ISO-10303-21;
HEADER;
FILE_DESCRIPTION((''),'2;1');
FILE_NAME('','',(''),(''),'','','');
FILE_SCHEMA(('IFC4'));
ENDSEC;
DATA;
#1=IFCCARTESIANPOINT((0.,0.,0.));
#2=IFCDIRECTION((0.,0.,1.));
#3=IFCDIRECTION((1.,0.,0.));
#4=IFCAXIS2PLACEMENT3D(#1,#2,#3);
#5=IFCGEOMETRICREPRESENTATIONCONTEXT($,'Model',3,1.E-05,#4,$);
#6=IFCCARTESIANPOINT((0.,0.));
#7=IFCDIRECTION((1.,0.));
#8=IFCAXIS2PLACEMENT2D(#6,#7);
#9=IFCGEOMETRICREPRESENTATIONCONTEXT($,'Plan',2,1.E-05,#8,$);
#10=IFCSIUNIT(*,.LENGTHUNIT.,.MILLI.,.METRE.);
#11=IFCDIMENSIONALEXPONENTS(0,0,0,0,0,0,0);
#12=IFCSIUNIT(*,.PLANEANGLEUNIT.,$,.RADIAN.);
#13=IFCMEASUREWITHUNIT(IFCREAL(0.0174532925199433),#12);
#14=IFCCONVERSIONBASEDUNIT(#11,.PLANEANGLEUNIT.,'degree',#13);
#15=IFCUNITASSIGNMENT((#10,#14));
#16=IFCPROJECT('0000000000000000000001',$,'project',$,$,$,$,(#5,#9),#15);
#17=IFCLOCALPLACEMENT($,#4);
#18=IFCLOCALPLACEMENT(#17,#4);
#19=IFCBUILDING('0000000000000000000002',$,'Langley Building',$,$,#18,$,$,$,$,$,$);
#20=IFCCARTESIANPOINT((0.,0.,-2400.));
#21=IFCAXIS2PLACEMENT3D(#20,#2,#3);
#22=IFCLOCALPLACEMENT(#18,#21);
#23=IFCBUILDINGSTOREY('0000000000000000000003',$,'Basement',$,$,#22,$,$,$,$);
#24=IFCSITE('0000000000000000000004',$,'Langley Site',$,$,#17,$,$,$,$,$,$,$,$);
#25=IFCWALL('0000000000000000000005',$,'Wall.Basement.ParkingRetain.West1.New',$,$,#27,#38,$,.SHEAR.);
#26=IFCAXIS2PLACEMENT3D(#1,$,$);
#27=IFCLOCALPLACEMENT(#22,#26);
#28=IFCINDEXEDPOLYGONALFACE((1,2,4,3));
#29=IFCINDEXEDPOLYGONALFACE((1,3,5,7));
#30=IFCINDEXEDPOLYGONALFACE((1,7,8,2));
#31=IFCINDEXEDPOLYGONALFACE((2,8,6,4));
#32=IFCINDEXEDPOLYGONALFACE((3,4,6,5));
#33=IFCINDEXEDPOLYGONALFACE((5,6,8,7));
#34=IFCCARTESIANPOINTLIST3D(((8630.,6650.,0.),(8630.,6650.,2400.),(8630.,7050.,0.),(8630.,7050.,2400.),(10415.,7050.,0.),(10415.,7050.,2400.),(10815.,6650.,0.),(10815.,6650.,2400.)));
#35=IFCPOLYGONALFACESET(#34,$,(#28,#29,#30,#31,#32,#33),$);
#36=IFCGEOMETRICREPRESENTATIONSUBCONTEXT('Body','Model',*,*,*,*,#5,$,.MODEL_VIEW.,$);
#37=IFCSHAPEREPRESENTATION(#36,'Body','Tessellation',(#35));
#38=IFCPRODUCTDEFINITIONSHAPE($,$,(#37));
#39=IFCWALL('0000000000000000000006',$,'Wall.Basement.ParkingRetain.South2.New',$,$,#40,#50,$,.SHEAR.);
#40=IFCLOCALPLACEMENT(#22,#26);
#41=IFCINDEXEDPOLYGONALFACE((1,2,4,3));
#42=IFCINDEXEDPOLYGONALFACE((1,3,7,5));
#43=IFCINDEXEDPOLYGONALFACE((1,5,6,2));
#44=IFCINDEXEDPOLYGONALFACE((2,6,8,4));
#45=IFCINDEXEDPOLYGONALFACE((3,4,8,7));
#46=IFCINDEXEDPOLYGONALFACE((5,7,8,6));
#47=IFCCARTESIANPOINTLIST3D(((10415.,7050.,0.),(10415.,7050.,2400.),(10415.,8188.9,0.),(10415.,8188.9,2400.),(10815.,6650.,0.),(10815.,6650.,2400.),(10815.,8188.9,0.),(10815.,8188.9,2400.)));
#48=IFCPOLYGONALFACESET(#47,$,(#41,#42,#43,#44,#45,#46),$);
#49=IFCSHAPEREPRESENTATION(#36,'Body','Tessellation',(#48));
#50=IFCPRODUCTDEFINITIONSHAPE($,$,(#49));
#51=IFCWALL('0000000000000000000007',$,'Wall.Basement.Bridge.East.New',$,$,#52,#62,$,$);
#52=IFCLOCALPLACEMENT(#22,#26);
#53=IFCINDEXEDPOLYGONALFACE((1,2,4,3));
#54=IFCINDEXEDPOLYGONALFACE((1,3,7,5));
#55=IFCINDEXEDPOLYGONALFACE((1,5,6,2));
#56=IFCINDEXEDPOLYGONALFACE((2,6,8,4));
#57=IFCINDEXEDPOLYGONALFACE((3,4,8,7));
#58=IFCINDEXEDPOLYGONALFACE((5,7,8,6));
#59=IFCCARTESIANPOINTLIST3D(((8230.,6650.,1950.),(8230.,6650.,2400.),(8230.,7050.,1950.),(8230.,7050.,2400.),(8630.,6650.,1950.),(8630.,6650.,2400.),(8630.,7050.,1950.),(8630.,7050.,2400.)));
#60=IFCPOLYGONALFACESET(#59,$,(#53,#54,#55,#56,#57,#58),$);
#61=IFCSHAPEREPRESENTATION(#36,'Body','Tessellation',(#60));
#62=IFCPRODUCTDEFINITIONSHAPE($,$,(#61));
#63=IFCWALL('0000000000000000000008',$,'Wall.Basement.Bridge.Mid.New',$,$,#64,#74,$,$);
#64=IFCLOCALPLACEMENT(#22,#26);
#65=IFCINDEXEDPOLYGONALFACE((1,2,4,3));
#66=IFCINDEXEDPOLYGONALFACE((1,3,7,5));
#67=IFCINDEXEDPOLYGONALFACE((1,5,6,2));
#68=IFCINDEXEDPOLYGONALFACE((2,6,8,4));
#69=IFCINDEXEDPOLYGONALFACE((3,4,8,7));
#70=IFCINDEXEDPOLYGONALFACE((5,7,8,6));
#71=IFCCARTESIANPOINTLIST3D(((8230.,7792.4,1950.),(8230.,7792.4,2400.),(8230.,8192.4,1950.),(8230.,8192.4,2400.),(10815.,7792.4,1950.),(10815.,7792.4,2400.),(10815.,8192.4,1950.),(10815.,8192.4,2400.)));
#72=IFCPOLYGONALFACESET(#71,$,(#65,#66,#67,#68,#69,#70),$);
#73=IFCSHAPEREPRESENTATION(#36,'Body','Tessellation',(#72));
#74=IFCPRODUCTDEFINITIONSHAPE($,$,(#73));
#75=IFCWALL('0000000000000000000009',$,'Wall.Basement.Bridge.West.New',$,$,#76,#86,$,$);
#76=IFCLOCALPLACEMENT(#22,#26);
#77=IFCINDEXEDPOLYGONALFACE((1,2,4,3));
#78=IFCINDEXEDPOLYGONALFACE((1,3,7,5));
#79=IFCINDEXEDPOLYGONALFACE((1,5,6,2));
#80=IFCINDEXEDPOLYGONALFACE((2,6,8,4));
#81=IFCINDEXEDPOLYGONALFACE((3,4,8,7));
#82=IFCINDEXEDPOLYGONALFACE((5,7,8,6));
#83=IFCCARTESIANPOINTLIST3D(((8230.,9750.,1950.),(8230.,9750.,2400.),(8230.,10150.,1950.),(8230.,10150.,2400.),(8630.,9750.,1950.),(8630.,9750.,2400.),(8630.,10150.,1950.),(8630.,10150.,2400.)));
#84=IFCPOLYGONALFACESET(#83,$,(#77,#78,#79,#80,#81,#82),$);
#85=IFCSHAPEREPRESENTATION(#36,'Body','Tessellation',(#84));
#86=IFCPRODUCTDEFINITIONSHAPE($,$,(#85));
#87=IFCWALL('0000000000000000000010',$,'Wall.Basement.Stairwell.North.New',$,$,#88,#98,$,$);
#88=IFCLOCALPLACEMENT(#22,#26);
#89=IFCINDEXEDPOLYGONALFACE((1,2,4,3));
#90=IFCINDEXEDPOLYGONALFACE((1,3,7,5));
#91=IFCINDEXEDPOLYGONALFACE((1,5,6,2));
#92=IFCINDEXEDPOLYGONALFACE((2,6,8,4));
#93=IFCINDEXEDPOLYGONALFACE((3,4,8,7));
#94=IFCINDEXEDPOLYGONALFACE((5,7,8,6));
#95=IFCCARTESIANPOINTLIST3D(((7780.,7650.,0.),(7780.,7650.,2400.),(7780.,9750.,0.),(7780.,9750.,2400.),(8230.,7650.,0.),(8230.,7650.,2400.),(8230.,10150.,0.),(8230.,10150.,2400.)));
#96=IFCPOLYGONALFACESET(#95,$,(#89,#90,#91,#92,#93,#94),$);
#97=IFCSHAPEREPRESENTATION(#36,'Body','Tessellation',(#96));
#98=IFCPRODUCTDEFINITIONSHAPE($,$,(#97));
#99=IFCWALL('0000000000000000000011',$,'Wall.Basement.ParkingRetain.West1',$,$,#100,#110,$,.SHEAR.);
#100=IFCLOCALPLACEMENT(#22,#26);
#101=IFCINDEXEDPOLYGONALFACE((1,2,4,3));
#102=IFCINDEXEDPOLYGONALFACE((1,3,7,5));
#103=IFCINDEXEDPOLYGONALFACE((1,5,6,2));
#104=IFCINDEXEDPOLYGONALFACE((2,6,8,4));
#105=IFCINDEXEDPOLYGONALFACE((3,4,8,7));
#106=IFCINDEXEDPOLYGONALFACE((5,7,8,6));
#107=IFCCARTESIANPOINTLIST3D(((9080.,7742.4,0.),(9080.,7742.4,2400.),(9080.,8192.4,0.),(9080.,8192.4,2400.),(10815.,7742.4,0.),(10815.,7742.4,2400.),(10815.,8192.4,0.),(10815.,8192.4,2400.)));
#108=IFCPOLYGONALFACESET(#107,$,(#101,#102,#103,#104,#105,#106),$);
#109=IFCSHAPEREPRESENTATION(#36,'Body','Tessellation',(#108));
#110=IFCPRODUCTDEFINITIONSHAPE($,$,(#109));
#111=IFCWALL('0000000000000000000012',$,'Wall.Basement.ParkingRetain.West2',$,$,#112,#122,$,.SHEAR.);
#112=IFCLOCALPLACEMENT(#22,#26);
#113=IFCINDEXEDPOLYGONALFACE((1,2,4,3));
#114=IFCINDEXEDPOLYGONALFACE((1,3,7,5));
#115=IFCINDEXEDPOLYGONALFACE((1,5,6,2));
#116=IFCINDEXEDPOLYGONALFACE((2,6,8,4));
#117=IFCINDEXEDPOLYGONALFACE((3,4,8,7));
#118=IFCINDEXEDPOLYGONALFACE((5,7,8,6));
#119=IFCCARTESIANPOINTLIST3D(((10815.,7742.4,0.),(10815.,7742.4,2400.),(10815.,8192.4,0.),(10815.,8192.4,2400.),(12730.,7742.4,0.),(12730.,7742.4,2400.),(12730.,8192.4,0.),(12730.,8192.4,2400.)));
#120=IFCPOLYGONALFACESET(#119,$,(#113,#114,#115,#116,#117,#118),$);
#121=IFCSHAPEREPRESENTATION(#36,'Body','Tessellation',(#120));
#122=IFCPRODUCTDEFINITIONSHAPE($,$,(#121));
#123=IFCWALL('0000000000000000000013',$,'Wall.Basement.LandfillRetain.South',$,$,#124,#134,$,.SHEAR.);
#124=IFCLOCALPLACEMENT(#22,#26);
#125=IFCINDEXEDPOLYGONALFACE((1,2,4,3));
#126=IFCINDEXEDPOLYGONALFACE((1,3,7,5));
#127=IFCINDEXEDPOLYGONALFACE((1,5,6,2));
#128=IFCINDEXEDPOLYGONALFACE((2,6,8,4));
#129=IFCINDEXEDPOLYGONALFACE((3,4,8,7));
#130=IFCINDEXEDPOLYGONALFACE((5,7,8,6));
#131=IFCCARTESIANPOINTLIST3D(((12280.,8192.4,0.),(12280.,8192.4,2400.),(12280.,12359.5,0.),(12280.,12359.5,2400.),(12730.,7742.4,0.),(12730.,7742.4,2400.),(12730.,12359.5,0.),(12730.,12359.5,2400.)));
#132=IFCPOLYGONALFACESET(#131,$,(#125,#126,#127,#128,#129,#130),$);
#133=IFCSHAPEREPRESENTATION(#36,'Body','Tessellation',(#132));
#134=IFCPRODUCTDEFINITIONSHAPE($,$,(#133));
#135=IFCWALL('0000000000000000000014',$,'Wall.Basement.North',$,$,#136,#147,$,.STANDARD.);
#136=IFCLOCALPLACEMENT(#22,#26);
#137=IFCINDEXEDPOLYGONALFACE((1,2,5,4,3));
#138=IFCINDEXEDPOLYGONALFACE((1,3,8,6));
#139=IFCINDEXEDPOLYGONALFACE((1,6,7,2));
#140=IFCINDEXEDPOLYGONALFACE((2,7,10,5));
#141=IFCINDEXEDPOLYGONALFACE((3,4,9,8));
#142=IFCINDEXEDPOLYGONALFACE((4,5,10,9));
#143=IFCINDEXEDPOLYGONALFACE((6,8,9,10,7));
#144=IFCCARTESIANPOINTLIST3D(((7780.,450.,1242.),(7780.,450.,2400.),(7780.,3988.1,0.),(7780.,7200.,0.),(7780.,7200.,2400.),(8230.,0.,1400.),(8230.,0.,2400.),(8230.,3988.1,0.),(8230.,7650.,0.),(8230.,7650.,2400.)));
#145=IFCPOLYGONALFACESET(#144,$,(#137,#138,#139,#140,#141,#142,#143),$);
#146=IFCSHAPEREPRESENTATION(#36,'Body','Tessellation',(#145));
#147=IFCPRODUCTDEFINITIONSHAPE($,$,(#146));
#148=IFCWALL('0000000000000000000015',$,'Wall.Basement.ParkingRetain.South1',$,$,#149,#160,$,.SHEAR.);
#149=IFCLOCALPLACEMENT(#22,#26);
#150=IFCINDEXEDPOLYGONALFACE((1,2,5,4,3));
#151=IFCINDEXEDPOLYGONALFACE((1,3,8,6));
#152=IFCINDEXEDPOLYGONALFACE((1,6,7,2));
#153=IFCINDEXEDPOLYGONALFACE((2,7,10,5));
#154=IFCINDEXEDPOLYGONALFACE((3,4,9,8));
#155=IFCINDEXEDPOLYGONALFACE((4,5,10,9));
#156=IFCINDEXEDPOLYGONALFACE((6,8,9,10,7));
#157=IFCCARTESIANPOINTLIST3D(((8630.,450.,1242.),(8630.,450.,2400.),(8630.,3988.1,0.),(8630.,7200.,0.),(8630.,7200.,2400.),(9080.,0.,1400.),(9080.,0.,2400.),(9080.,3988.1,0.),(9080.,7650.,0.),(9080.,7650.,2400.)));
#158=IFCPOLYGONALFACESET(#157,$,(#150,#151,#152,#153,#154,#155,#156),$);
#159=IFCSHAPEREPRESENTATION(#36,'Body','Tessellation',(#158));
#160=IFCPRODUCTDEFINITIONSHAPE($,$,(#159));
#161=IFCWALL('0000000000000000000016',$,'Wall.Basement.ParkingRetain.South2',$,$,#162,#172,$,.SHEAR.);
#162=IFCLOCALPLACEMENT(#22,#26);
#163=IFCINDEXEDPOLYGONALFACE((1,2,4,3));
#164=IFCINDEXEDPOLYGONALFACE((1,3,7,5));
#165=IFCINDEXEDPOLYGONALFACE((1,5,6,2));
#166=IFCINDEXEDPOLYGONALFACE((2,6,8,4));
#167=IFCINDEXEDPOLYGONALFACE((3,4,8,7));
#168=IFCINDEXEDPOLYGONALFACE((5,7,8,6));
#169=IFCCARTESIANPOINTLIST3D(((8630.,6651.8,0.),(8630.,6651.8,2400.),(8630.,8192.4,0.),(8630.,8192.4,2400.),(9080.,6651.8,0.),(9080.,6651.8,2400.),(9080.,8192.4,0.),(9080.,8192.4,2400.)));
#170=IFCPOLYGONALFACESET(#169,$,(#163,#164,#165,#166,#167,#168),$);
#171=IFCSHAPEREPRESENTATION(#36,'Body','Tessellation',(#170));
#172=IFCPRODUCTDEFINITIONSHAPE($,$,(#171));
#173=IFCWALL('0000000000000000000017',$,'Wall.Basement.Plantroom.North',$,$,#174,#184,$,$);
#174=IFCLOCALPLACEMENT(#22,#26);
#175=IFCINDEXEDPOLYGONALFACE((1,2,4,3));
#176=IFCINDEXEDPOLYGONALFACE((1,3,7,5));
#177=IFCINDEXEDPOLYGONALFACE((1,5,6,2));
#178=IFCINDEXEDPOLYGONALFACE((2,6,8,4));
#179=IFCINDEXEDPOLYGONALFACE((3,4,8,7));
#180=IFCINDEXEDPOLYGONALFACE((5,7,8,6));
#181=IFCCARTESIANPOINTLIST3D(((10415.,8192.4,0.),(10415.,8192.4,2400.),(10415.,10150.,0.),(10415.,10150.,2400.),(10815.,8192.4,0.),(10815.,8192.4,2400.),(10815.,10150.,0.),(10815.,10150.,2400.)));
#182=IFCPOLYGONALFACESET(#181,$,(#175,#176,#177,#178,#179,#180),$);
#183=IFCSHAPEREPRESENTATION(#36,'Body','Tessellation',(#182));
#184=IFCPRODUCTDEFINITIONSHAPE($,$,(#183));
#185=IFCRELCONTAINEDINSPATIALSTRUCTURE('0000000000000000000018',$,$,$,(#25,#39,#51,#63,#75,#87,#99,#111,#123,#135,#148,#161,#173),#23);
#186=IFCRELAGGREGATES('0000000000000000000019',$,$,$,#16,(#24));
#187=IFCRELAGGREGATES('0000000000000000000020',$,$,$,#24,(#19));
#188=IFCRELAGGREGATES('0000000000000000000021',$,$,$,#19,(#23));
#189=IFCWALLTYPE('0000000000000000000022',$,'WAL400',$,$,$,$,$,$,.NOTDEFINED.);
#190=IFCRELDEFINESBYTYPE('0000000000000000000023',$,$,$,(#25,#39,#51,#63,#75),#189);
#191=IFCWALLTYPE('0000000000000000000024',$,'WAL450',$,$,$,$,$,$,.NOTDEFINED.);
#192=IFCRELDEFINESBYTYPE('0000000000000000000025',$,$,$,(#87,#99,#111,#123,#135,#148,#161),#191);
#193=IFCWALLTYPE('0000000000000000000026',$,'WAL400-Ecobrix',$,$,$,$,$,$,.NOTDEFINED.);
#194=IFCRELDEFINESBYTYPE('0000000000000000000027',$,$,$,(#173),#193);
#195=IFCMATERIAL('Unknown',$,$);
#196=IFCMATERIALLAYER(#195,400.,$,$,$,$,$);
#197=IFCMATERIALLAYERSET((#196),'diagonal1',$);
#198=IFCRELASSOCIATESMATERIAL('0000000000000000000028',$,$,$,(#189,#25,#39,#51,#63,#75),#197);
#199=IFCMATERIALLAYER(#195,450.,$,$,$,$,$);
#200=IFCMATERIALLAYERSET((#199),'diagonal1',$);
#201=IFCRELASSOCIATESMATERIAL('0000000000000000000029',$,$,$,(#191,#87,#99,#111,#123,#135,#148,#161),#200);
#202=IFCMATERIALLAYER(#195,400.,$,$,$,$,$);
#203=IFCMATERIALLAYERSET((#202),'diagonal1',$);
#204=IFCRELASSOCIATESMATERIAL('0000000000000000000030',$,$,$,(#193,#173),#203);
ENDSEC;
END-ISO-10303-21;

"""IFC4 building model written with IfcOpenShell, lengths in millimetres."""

from ifc_helpers import new_model, entity, si_unit, converted_unit, frame, origin_with_axes, origin_2d_with_axis, place, context, subcontext, project, spatial, line, indexed_curve, outline, extrude, clip, halfspace, material, layer, layer_set, layer_usage, type_object, element, save


model = new_model("IFC4")

# Units and contexts
model_context = context("Model", 3, precision=1e-05, world=origin_with_axes())
plan_context = context("Plan", 2, precision=1e-05, world=origin_2d_with_axis())
body_context_1 = subcontext(model_context, "Body", "Model", "MODEL_VIEW")
ifc_project = project(units=[si_unit("LENGTHUNIT", "METRE", prefix="MILLI"), converted_unit("PLANEANGLEUNIT", "degree", entity("IfcReal", 0.0174532925199433), si_unit("PLANEANGLEUNIT", "RADIAN"), dimensions=[0, 0, 0, 0, 0, 0, 0])], contexts=[model_context, plan_context])

# Site, building, storey
site_placement = place(None, origin_with_axes())
site = spatial("IfcSite", under=ifc_project, at=site_placement, Name="Langley Site")
building_placement = place(site_placement, origin_with_axes())
building = spatial("IfcBuilding", under=site, at=building_placement, Name="Langley Building")
storey_placement = place(building_placement, frame((0.0, 0.0, -2400.0), z_axis=(0.0, 0.0, 1.0), x_axis=(1.0, 0.0, 0.0)))
storey = spatial("IfcBuildingStorey", under=building, at=storey_placement, Name="Basement")

# Walls
ifc_material = material(Name="Unknown")
ifc_layer_1 = layer(ifc_material, 400.0)
ifc_layer_set_1 = layer_set([ifc_layer_1], Name="diagonal1")
ifc_layer_usage_1 = layer_usage(ifc_layer_set_1, "AXIS2", "POSITIVE", 0.0)
wall_type_1 = type_object("IfcWallType", Name="WAL400", PredefinedType="NOTDEFINED", material=ifc_layer_set_1)
wall_1_placement = place(storey_placement, frame((8630.0, 6650.0, 0.0), z_axis=(0.0, 0.0, 1.0), x_axis=(1.0, 0.0, 0.0)))
element("IfcWall", 1, at=wall_1_placement, inside=storey, type_object=wall_type_1, material=ifc_layer_usage_1, Name="Wall.Basement.ParkingRetain.West1.New", PredefinedType="SHEAR", context=body_context_1, shape_type="SweptSolid", body=[
    extrude(outline(indexed_curve([(0.0, 0.0), (0.0, 400.0), (1785.0, 400.0), (2185.0, 0.0)], segments=[line(1, 2, 3, 4, 1)])), origin_with_axes(), (0.0, 0.0, 1.0), 2400.0),
])
ifc_layer_usage_2 = layer_usage(ifc_layer_set_1, "AXIS2", "POSITIVE", 0.0)
wall_2_placement = place(storey_placement, frame((10815.0, 6650.0, 0.0), z_axis=(0.0, 0.0, 1.0), x_axis=(0.0, 1.0, 0.0)))
element("IfcWall", 2, at=wall_2_placement, inside=storey, type_object=wall_type_1, material=ifc_layer_usage_2, Name="Wall.Basement.ParkingRetain.South2.New", PredefinedType="SHEAR", context=body_context_1, shape_type="SweptSolid", body=[
    extrude(outline(indexed_curve([(0.0, 0.0), (400.0, 400.0), (1538.9, 400.0), (1538.9, 0.0)], segments=[line(1, 2, 3, 4, 1)])), origin_with_axes(), (0.0, 0.0, 1.0), 2400.0),
])
ifc_layer_usage_3 = layer_usage(ifc_layer_set_1, "AXIS2", "POSITIVE", 0.0)
wall_3_placement = place(storey_placement, frame((8630.0, 7050.0, 1950.0), z_axis=(0.0, 0.0, 1.0), x_axis=(-1.0, 0.0, 0.0)))
element("IfcWall", 3, at=wall_3_placement, inside=storey, type_object=wall_type_1, material=ifc_layer_usage_3, Name="Wall.Basement.Bridge.East.New", context=body_context_1, shape_type="SweptSolid", body=[
    extrude(outline(indexed_curve([(0.0, 0.0), (0.0, 400.0), (400.0, 400.0), (400.0, 0.0)], segments=[line(1, 2, 3, 4, 1)])), origin_with_axes(), (0.0, 0.0, 1.0), 450.0),
])
ifc_layer_usage_4 = layer_usage(ifc_layer_set_1, "AXIS2", "POSITIVE", 0.0)
wall_4_placement = place(storey_placement, frame((10815.0, 8192.4, 1950.0), z_axis=(0.0, 0.0, 1.0), x_axis=(-1.0, 0.0, 0.0)))
element("IfcWall", 4, at=wall_4_placement, inside=storey, type_object=wall_type_1, material=ifc_layer_usage_4, Name="Wall.Basement.Bridge.Mid.New", context=body_context_1, shape_type="SweptSolid", body=[
    extrude(outline(indexed_curve([(0.0, 0.0), (0.0, 400.0), (2585.0, 400.0), (2585.0, 0.0)], segments=[line(1, 2, 3, 4, 1)])), origin_with_axes(), (0.0, 0.0, 1.0), 450.0),
])
ifc_layer_usage_5 = layer_usage(ifc_layer_set_1, "AXIS2", "POSITIVE", 0.0)
wall_5_placement = place(storey_placement, frame((8630.0, 10150.0, 1950.0), z_axis=(0.0, 0.0, 1.0), x_axis=(-1.0, 0.0, 0.0)))
element("IfcWall", 5, at=wall_5_placement, inside=storey, type_object=wall_type_1, material=ifc_layer_usage_5, Name="Wall.Basement.Bridge.West.New", context=body_context_1, shape_type="SweptSolid", body=[
    extrude(outline(indexed_curve([(0.0, 0.0), (0.0, 400.0), (400.0, 400.0), (400.0, 0.0)], segments=[line(1, 2, 3, 4, 1)])), origin_with_axes(), (0.0, 0.0, 1.0), 450.0),
])
ifc_layer_2 = layer(ifc_material, 450.0)
ifc_layer_set_2 = layer_set([ifc_layer_2], Name="diagonal1")
ifc_layer_usage_6 = layer_usage(ifc_layer_set_2, "AXIS2", "POSITIVE", 0.0)
wall_type_2 = type_object("IfcWallType", Name="WAL450", PredefinedType="NOTDEFINED", material=ifc_layer_set_2)
wall_6_placement = place(storey_placement, frame((8230.0, 7650.0, 0.0), z_axis=(0.0, 0.0, 1.0), x_axis=(-0.000001, 1.0, 0.0)))
element("IfcWall", 6, at=wall_6_placement, inside=storey, type_object=wall_type_2, material=ifc_layer_usage_6, Name="Wall.Basement.Stairwell.North.New", context=body_context_1, shape_type="SweptSolid", body=[
    extrude(outline(indexed_curve([(0.0, 0.0), (0.0, 450.0), (2100.0, 450.0), (2500.0, 0.0)], segments=[line(1, 2, 3, 4, 1)])), origin_with_axes(), (0.0, 0.0, 1.0), 2400.0),
])
ifc_layer_usage_7 = layer_usage(ifc_layer_set_2, "AXIS2", "POSITIVE", 0.0)
wall_7_placement = place(storey_placement, frame((9080.0, 7742.4, 0.0), z_axis=(0.0, 0.0, 1.0), x_axis=(1.0, 0.0, 0.0)))
element("IfcWall", 7, at=wall_7_placement, inside=storey, type_object=wall_type_2, material=ifc_layer_usage_7, Name="Wall.Basement.ParkingRetain.West1", PredefinedType="SHEAR", context=body_context_1, shape_type="SweptSolid", body=[
    extrude(outline(indexed_curve([(0.0, 0.0), (0.0, 450.0), (1735.0, 450.0), (1735.0, 0.0)], segments=[line(1, 2, 3, 4, 1)])), origin_with_axes(), (0.0, 0.0, 1.0), 2400.0),
])
ifc_layer_usage_8 = layer_usage(ifc_layer_set_2, "AXIS2", "POSITIVE", 0.0)
wall_8_placement = place(storey_placement, frame((10815.0, 7742.4, 0.0), z_axis=(0.0, 0.0, 1.0), x_axis=(1.0, 0.0, 0.0)))
element("IfcWall", 8, at=wall_8_placement, inside=storey, type_object=wall_type_2, material=ifc_layer_usage_8, Name="Wall.Basement.ParkingRetain.West2", PredefinedType="SHEAR", context=body_context_1, shape_type="SweptSolid", body=[
    extrude(outline(indexed_curve([(0.0, 0.0), (0.0, 450.0), (1915.0, 450.0), (1915.0, 0.0)], segments=[line(1, 2, 3, 4, 1)])), origin_with_axes(), (0.0, 0.0, 1.0), 2400.0),
])
ifc_layer_usage_9 = layer_usage(ifc_layer_set_2, "AXIS2", "POSITIVE", 0.0)
wall_9_placement = place(storey_placement, frame((12730.0, 7742.4, 0.0), z_axis=(0.0, 0.0, 1.0), x_axis=(0.0, 1.0, 0.0)))
element("IfcWall", 9, at=wall_9_placement, inside=storey, type_object=wall_type_2, material=ifc_layer_usage_9, Name="Wall.Basement.LandfillRetain.South", PredefinedType="SHEAR", context=body_context_1, shape_type="SweptSolid", body=[
    extrude(outline(indexed_curve([(0.0, 0.0), (450.0, 450.0), (4617.0, 450.0), (4617.0, 0.0)], segments=[line(1, 2, 3, 4, 1)])), origin_with_axes(), (0.0, 0.0, 1.0), 2400.0),
])
ifc_layer_usage_10 = layer_usage(ifc_layer_set_2, "AXIS2", "POSITIVE", 0.0)
wall_10_placement = place(storey_placement, frame((8230.0, 0.0, 0.0), z_axis=(0.0, 0.0, 1.0), x_axis=(0.0, 1.0, 0.0)))
element("IfcWall", 10, at=wall_10_placement, inside=storey, type_object=wall_type_2, material=ifc_layer_usage_10, Name="Wall.Basement.North", PredefinedType="STANDARD", context=body_context_1, shape_type="Clipping", body=[
    clip(extrude(outline(indexed_curve([(0.0, 0.0), (450.0, 450.0), (7200.0, 450.0), (7650.0, 0.0)], segments=[line(1, 2, 3, 4, 1)])), origin_with_axes(), (0.0, 0.0, 1.0), 2400.0), halfspace(frame((0.0, -50.0, 1400.0), z_axis=(-0.331226, 0.0, -0.943551), x_axis=(0.943551, -0.000001, -0.331226)), False)),
])
ifc_layer_usage_11 = layer_usage(ifc_layer_set_2, "AXIS2", "POSITIVE", 0.0)
wall_11_placement = place(storey_placement, frame((9080.0, 0.0, 0.0), z_axis=(0.0, 0.0, 1.0), x_axis=(0.0, 1.0, 0.0)))
element("IfcWall", 11, at=wall_11_placement, inside=storey, type_object=wall_type_2, material=ifc_layer_usage_11, Name="Wall.Basement.ParkingRetain.South1", PredefinedType="SHEAR", context=body_context_1, shape_type="Clipping", body=[
    clip(extrude(outline(indexed_curve([(0.0, 0.0), (450.0, 450.0), (7200.0, 450.0), (7650.0, 0.0)], segments=[line(1, 2, 3, 4, 1)])), origin_with_axes(), (0.0, 0.0, 1.0), 2400.0), halfspace(frame((0.0, -50.0, 1400.0), z_axis=(-0.331226, 0.0, -0.943551), x_axis=(0.943551, -0.000001, -0.331226)), False)),
])
ifc_layer_usage_12 = layer_usage(ifc_layer_set_2, "AXIS2", "POSITIVE", 0.0)
wall_12_placement = place(storey_placement, frame((9080.0, 6651.8, 0.0), z_axis=(0.0, 0.0, 1.0), x_axis=(0.0, 1.0, 0.0)))
element("IfcWall", 12, at=wall_12_placement, inside=storey, type_object=wall_type_2, material=ifc_layer_usage_12, Name="Wall.Basement.ParkingRetain.South2", PredefinedType="SHEAR", context=body_context_1, shape_type="SweptSolid", body=[
    extrude(outline(indexed_curve([(0.0, 0.0), (0.0, 450.0), (1540.6, 450.0), (1540.6, 0.0)], segments=[line(1, 2, 3, 4, 1)])), origin_with_axes(), (0.0, 0.0, 1.0), 2400.0),
])
ifc_layer_3 = layer(ifc_material, 400.0)
ifc_layer_set_3 = layer_set([ifc_layer_3], Name="diagonal1")
ifc_layer_usage_13 = layer_usage(ifc_layer_set_3, "AXIS2", "POSITIVE", 0.0)
wall_type_3 = type_object("IfcWallType", Name="WAL400-Ecobrix", PredefinedType="NOTDEFINED", material=ifc_layer_set_3)
wall_13_placement = place(storey_placement, frame((10815.0, 8192.4, 0.0), z_axis=(0.0, 0.0, 1.0), x_axis=(0.0, 1.0, 0.0)))
element("IfcWall", 13, at=wall_13_placement, inside=storey, type_object=wall_type_3, material=ifc_layer_usage_13, Name="Wall.Basement.Plantroom.North", context=body_context_1, shape_type="SweptSolid", body=[
    extrude(outline(indexed_curve([(0.0, 0.0), (0.0, 400.0), (1957.6, 400.0), (1957.6, 0.0)], segments=[line(1, 2, 3, 4, 1)])), origin_with_axes(), (0.0, 0.0, 1.0), 2400.0),
])

save(model, "model.ifc")
